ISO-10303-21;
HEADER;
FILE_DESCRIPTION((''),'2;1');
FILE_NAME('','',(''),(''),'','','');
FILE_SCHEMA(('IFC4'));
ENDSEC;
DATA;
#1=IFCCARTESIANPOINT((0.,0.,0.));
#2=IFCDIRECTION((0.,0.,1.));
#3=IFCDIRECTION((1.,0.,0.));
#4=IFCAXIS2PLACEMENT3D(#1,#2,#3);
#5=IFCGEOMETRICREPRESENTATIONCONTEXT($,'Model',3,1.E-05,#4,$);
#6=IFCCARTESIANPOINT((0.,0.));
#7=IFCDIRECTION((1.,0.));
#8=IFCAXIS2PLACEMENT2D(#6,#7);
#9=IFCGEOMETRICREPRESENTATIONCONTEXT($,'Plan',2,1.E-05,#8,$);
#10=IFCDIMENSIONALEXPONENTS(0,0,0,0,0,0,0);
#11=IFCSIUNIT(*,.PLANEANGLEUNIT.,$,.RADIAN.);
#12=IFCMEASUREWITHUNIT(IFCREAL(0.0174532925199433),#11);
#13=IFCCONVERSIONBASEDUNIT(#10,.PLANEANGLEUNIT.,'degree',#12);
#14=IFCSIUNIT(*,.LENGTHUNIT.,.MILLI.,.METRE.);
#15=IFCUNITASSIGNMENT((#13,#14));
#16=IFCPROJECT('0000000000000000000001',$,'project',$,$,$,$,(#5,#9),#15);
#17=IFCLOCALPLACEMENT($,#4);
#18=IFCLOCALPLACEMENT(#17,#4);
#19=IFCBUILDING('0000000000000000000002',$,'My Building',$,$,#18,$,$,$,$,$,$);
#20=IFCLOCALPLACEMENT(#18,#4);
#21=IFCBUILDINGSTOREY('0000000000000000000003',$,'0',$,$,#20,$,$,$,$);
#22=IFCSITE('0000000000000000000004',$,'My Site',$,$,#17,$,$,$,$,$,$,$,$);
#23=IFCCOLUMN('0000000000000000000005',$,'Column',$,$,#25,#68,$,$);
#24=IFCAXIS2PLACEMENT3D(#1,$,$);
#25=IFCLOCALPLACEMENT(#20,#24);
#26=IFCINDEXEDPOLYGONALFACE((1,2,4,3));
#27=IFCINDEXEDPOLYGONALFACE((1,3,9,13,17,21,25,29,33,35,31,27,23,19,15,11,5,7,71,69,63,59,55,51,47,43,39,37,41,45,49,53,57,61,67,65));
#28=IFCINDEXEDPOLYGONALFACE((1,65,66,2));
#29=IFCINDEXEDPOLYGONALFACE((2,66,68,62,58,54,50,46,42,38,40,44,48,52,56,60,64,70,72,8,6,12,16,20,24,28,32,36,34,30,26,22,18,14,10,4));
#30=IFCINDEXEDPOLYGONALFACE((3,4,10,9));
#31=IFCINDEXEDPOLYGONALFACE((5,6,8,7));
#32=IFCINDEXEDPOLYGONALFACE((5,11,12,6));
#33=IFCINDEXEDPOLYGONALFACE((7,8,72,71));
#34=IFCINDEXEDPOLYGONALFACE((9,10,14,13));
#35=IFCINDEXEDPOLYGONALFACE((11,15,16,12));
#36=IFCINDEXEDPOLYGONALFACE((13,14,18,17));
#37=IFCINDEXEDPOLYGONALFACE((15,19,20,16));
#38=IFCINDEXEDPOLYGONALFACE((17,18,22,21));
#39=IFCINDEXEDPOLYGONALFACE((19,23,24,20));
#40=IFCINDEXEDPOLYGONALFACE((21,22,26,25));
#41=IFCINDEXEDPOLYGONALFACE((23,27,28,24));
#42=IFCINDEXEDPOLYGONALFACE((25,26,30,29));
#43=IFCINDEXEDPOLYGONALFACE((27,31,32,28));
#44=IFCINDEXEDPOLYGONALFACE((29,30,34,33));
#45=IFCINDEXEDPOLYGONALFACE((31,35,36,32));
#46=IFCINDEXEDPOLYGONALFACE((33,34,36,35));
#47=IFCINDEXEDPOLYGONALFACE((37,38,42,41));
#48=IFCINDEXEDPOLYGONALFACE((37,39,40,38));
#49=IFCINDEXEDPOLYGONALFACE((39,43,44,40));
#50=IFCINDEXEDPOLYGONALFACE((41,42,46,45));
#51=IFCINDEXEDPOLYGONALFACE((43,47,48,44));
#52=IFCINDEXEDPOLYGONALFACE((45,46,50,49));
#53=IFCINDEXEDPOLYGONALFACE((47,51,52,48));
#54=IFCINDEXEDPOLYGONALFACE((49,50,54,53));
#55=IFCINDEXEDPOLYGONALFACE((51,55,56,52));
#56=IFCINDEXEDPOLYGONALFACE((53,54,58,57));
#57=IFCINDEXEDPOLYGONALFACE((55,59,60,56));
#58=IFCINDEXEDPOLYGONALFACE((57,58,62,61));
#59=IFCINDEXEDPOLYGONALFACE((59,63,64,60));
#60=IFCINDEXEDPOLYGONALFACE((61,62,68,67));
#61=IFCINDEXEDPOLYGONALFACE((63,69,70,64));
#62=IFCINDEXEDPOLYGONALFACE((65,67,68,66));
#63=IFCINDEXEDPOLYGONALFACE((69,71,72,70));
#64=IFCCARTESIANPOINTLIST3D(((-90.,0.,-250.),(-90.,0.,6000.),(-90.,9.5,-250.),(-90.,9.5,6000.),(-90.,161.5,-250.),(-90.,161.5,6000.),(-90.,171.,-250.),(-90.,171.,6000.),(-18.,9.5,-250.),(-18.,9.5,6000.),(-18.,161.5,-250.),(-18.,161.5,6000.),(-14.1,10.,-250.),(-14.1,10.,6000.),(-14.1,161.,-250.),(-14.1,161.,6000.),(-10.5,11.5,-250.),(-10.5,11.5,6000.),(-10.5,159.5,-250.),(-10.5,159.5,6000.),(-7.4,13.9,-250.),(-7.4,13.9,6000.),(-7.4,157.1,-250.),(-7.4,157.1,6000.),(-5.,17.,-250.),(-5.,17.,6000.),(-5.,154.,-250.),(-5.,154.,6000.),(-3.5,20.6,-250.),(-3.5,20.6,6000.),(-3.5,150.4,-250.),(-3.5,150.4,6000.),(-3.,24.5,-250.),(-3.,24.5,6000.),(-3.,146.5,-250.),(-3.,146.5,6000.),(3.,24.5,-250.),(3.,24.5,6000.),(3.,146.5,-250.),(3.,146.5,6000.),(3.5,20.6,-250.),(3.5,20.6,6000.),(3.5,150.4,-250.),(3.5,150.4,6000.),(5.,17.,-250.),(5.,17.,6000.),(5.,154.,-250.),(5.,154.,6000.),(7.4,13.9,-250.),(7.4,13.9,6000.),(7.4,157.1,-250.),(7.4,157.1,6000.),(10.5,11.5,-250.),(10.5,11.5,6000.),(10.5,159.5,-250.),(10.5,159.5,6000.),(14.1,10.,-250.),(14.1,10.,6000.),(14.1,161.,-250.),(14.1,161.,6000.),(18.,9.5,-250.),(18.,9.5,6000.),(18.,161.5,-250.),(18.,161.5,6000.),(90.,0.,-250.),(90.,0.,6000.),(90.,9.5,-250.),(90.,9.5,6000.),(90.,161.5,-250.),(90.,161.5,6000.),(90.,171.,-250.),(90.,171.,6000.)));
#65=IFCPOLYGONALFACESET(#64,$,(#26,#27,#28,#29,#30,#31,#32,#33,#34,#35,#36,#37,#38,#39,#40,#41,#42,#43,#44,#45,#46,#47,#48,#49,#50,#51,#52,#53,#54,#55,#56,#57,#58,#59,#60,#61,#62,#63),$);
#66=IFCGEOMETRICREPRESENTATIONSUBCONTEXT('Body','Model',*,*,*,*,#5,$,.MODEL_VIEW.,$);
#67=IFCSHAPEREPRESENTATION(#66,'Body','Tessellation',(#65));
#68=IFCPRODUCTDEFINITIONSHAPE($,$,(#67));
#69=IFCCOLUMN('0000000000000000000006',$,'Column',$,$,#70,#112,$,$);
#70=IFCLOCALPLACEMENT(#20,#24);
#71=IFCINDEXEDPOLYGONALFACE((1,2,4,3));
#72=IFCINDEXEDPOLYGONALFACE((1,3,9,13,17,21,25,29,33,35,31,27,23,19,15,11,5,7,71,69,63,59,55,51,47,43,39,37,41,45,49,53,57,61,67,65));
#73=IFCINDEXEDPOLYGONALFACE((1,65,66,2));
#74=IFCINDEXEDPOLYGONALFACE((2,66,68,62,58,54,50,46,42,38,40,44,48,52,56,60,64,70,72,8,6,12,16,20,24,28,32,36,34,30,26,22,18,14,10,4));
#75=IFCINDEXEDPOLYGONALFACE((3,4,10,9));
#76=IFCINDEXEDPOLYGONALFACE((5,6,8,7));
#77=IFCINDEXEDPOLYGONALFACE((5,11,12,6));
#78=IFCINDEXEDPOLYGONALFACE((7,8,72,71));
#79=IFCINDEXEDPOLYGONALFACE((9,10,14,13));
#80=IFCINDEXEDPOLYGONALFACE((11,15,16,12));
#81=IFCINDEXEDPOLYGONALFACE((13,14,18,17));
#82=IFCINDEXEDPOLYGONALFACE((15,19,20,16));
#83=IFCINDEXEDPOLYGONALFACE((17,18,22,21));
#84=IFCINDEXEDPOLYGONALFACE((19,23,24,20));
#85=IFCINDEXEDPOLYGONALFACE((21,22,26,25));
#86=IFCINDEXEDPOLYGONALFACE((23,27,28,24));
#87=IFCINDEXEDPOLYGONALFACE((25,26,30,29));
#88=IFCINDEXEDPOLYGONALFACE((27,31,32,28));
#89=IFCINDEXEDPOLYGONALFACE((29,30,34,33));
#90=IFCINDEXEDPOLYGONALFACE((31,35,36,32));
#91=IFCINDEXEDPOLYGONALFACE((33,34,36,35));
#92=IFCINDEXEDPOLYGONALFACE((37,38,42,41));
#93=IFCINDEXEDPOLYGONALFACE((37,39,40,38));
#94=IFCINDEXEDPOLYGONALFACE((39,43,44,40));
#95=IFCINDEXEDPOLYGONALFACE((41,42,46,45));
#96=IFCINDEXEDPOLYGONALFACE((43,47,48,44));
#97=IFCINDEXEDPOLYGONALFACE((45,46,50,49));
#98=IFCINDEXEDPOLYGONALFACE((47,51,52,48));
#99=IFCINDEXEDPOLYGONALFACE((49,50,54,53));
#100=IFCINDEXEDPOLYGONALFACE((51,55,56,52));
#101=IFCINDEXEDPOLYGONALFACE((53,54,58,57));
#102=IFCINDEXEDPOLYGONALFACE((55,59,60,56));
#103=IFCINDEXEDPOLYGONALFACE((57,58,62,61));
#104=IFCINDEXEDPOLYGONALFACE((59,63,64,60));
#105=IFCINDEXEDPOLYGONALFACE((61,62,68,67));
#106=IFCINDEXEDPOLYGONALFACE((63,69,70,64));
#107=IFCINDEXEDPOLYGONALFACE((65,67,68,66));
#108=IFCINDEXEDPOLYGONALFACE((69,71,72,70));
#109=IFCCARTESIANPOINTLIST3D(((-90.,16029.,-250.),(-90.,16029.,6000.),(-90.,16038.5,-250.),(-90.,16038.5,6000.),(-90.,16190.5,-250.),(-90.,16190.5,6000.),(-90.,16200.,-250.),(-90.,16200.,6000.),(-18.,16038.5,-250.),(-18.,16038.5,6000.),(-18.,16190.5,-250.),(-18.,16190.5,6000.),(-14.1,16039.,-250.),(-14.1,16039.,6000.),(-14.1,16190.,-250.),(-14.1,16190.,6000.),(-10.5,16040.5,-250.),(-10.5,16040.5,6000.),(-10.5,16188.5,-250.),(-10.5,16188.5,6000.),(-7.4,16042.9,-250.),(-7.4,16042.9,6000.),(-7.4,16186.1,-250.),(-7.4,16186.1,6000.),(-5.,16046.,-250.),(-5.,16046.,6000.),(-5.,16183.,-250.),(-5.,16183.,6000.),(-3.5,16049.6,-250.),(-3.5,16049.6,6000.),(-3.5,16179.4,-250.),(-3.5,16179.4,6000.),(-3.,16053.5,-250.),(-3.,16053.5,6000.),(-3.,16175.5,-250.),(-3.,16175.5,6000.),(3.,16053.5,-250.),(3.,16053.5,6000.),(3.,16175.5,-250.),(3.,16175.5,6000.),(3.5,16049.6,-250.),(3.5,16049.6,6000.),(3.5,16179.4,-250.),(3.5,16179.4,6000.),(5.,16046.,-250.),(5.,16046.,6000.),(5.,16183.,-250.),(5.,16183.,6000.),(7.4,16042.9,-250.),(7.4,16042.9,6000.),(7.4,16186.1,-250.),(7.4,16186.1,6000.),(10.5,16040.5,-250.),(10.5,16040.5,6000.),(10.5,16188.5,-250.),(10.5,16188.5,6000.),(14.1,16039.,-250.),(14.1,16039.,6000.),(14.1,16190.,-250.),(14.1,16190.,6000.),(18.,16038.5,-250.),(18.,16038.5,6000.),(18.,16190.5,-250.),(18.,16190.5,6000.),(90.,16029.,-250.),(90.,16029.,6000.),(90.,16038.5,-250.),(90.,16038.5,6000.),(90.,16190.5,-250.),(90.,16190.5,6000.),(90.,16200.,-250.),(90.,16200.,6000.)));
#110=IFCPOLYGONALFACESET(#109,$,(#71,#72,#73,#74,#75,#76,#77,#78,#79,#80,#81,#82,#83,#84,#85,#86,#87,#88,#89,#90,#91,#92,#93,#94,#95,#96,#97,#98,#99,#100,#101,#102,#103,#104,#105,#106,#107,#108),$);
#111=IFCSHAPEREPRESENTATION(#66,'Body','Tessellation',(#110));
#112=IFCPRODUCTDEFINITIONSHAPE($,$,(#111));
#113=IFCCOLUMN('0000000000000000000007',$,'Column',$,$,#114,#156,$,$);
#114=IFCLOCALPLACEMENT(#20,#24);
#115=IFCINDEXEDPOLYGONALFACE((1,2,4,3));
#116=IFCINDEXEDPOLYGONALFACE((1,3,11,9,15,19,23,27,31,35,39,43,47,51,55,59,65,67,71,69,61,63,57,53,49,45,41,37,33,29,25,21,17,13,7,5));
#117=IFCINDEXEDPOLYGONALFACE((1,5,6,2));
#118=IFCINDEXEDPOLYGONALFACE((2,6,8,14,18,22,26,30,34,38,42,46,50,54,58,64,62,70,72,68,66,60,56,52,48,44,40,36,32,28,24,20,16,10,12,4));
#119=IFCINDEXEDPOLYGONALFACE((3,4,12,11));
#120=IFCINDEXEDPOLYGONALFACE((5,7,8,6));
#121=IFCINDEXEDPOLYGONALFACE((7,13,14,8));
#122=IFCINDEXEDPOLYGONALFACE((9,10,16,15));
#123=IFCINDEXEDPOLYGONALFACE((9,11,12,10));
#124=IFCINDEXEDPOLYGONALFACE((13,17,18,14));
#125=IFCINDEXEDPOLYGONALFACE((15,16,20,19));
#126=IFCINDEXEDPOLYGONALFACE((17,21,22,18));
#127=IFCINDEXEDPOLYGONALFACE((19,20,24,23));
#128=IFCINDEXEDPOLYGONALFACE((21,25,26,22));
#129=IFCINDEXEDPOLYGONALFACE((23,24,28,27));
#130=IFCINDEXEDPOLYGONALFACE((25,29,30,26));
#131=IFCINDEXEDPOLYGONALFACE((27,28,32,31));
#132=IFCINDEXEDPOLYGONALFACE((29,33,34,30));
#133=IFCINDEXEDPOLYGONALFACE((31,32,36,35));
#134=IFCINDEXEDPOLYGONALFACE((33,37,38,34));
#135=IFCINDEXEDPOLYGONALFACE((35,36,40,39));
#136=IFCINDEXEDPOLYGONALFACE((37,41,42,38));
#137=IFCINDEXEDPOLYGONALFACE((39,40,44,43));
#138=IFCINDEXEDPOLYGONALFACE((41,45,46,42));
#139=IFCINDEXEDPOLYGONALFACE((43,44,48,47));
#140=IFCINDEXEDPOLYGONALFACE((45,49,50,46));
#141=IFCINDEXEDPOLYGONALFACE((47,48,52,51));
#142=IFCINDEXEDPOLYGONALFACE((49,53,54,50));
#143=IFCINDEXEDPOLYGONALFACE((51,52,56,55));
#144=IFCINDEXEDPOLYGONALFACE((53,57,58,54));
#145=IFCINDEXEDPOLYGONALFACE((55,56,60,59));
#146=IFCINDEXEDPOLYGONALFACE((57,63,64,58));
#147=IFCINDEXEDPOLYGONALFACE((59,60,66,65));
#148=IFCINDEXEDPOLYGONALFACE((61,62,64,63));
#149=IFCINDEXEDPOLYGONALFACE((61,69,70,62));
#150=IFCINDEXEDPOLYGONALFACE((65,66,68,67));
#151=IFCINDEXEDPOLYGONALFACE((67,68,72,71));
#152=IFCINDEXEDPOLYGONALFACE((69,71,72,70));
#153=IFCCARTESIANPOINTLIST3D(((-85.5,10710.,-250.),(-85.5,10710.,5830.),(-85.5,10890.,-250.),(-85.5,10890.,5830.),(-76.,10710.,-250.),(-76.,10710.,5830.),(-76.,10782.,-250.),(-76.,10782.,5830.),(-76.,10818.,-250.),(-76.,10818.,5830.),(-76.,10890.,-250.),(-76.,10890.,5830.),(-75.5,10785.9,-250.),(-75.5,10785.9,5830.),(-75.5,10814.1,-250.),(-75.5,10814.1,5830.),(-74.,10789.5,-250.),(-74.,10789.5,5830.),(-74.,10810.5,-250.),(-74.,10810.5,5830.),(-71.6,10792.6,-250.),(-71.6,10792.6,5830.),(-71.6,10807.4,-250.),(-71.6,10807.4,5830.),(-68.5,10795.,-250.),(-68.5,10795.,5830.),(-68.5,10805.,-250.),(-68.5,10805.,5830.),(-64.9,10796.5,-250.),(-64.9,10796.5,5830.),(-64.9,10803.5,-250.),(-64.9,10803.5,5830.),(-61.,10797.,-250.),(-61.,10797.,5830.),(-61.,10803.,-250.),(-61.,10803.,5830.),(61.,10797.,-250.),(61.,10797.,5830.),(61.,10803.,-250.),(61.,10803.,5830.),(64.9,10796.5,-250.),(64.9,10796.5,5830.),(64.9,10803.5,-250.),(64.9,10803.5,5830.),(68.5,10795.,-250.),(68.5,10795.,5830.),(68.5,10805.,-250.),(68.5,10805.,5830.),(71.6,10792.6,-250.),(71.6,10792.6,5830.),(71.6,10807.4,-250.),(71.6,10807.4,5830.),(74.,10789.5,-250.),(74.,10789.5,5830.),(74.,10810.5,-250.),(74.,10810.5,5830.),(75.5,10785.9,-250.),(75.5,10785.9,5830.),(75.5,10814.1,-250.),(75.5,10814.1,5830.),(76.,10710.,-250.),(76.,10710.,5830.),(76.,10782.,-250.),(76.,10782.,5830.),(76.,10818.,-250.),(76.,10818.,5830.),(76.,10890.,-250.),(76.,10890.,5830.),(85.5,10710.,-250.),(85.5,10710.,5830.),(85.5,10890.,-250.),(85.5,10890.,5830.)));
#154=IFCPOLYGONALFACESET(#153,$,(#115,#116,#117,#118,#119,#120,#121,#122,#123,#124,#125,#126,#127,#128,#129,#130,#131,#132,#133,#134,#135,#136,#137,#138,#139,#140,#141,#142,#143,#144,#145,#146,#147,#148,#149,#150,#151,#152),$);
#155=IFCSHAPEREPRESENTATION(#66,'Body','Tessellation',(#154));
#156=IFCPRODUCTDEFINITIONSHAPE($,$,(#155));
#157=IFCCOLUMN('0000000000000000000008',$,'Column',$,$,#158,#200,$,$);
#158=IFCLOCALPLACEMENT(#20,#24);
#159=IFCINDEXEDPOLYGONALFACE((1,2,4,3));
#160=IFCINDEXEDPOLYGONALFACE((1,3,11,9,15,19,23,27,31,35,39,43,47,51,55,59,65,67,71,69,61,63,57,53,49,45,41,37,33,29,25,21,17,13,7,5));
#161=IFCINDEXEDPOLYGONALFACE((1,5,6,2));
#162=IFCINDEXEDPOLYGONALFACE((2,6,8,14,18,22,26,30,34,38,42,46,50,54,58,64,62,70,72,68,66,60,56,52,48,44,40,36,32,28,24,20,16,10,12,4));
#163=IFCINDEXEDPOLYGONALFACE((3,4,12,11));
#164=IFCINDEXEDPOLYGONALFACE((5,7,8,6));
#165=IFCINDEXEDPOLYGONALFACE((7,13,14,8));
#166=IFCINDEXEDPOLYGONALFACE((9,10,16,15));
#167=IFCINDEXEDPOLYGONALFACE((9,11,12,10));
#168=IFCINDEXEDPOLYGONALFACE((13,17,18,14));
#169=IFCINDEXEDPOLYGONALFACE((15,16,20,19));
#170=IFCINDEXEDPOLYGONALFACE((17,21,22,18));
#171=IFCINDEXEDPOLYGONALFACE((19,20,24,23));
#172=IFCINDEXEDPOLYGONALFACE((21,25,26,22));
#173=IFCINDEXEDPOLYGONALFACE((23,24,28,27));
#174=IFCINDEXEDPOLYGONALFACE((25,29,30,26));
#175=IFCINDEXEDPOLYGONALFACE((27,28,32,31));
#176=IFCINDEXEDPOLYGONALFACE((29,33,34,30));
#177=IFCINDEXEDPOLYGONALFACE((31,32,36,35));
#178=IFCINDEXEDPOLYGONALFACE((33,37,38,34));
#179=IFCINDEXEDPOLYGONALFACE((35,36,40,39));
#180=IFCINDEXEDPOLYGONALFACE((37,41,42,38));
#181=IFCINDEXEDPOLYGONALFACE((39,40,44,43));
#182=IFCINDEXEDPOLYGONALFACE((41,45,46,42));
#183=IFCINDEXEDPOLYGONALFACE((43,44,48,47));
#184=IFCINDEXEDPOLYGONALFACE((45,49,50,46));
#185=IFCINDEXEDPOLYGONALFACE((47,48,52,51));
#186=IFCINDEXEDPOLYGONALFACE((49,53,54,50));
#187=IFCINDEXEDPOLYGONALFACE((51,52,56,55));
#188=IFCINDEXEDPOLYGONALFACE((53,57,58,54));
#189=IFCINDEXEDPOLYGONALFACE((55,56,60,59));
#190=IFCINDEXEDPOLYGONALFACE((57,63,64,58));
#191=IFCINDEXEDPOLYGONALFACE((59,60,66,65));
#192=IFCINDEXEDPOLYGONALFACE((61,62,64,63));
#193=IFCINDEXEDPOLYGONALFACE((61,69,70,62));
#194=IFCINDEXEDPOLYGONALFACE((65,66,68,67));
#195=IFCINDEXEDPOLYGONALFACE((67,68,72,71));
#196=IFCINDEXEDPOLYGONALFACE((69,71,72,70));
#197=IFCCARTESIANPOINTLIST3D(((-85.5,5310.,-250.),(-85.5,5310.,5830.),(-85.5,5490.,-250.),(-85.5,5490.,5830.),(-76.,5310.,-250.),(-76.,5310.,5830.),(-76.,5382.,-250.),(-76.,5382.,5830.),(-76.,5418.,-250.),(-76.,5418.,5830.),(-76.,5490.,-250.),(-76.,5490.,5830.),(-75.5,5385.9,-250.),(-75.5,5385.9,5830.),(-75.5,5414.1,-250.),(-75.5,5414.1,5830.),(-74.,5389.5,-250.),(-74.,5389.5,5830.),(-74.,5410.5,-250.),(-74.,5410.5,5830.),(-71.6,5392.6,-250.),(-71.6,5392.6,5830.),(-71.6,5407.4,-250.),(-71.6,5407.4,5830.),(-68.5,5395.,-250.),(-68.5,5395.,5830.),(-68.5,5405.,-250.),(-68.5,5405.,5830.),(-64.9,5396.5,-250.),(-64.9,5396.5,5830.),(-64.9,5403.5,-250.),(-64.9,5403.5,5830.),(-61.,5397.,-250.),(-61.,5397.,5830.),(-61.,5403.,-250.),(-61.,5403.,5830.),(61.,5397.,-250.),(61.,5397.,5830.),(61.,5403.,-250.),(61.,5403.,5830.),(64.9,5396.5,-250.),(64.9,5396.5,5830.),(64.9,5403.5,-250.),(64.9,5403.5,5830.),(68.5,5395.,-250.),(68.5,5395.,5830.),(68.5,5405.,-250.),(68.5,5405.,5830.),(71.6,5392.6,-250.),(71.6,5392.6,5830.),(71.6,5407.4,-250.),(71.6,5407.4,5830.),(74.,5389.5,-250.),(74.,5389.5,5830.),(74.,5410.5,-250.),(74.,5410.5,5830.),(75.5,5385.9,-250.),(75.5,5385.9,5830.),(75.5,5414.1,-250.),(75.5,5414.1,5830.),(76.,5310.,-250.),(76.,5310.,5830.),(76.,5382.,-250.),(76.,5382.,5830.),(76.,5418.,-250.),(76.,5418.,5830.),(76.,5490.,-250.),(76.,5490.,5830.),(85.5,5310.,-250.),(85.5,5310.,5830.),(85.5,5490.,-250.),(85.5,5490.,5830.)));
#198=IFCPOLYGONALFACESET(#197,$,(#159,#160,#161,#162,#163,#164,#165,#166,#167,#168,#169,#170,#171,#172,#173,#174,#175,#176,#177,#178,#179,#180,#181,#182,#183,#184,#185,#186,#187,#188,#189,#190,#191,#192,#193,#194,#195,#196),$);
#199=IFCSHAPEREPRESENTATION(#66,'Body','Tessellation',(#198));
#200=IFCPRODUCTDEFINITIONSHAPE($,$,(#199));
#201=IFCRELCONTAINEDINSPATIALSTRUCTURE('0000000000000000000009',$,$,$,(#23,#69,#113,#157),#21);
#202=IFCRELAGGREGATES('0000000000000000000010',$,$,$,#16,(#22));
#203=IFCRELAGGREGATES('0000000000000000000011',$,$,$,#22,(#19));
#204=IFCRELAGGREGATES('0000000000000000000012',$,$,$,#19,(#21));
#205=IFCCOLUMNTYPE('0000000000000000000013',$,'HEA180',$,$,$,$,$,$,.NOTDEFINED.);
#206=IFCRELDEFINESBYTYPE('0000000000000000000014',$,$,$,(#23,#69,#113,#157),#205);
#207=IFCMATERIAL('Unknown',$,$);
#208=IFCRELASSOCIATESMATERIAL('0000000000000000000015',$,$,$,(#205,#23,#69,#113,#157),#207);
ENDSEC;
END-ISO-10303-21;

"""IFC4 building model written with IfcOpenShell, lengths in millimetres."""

from ifc_helpers import new_model, entity, si_unit, converted_unit, frame, origin_with_axes, origin_2d_with_axis, place, context, subcontext, project, spatial, i_section, extrude, material, material_profile, profile_set, profile_usage, type_object, element, save


model = new_model("IFC4")

# Units and contexts
model_context = context("Model", 3, precision=1e-05, world=origin_with_axes())
plan_context = context("Plan", 2, precision=1e-05, world=origin_2d_with_axis())
body_context = subcontext(model_context, "Body", "Model", "MODEL_VIEW")
ifc_project = project(units=[converted_unit("PLANEANGLEUNIT", "degree", entity("IfcReal", 0.0174532925199433), si_unit("PLANEANGLEUNIT", "RADIAN"), dimensions=[0, 0, 0, 0, 0, 0, 0]), si_unit("LENGTHUNIT", "METRE", prefix="MILLI")], contexts=[model_context, plan_context])

# Site, building, storey
site_placement = place(None, origin_with_axes())
site = spatial("IfcSite", under=ifc_project, at=site_placement, Name="My Site")
building_placement = place(site_placement, origin_with_axes())
building = spatial("IfcBuilding", under=site, at=building_placement, Name="My Building")
storey_placement = place(building_placement, origin_with_axes())
storey = spatial("IfcBuildingStorey", under=building, at=storey_placement, Name="0")

# Columns
ifc_material = material(Name="Unknown")
ifc_material_profile_1 = material_profile(ifc_material, i_section(OverallWidth=180.0, OverallDepth=171.0, WebThickness=6.0, FlangeThickness=9.5, FilletRadius=15.0))
ifc_profile_set_1 = profile_set([ifc_material_profile_1])
ifc_profile_usage_1 = profile_usage(ifc_profile_set_1, cardinal=2)
column_type = type_object("IfcColumnType", Name="HEA180", PredefinedType="NOTDEFINED", material=ifc_profile_set_1)
column_1_placement = place(storey_placement, frame((0.0, 0.0, -250.0), z_axis=(0.0, 0.0, 1.0), x_axis=(1.0, 0.0, 0.0)))
element("IfcColumn", 1, at=column_1_placement, inside=storey, type_object=column_type, material=ifc_profile_usage_1, Name="Column", context=body_context, shape_type="SweptSolid", body=[
    extrude(i_section(OverallWidth=180.0, OverallDepth=171.0, WebThickness=6.0, FlangeThickness=9.5, FilletRadius=15.0), frame((0.0, 85.5, 0.0), z_axis=(0.0, 0.0, 1.0), x_axis=(1.0, 0.0, 0.0)), (0.0, 0.0, 1.0), 6250.0),
])
ifc_profile_usage_2 = profile_usage(ifc_profile_set_1, cardinal=8)
column_2_placement = place(storey_placement, frame((0.0, 16200.0, -250.0), z_axis=(0.0, 0.0, 1.0), x_axis=(1.0, 0.0, 0.0)))
element("IfcColumn", 2, at=column_2_placement, inside=storey, type_object=column_type, material=ifc_profile_usage_2, Name="Column", context=body_context, shape_type="SweptSolid", body=[
    extrude(i_section(OverallWidth=180.0, OverallDepth=171.0, WebThickness=6.0, FlangeThickness=9.5, FilletRadius=15.0), frame((0.0, -85.5, 0.0), z_axis=(0.0, 0.0, 1.0), x_axis=(1.0, 0.0, 0.0)), (0.0, 0.0, 1.0), 6250.0),
])
ifc_profile_usage_3 = profile_usage(ifc_profile_set_1, cardinal=10)
column_3_placement = place(storey_placement, frame((0.0, 10800.0, -250.0), z_axis=(0.0, 0.0, 1.0), x_axis=(0.0, 1.0, 0.0)))
element("IfcColumn", 3, at=column_3_placement, inside=storey, type_object=column_type, material=ifc_profile_usage_3, Name="Column", context=body_context, shape_type="SweptSolid", body=[
    extrude(i_section(OverallWidth=180.0, OverallDepth=171.0, WebThickness=6.0, FlangeThickness=9.5, FilletRadius=15.0), origin_with_axes(), (0.0, 0.0, 1.0), 6080.0),
])
ifc_profile_usage_4 = profile_usage(ifc_profile_set_1, cardinal=10)
column_4_placement = place(storey_placement, frame((0.0, 5400.0, -250.0), z_axis=(0.0, 0.0, 1.0), x_axis=(0.0, 1.0, 0.0)))
element("IfcColumn", 4, at=column_4_placement, inside=storey, type_object=column_type, material=ifc_profile_usage_4, Name="Column", context=body_context, shape_type="SweptSolid", body=[
    extrude(i_section(OverallWidth=180.0, OverallDepth=171.0, WebThickness=6.0, FlangeThickness=9.5, FilletRadius=15.0), origin_with_axes(), (0.0, 0.0, 1.0), 6080.0),
])

save(model, "model.ifc")
